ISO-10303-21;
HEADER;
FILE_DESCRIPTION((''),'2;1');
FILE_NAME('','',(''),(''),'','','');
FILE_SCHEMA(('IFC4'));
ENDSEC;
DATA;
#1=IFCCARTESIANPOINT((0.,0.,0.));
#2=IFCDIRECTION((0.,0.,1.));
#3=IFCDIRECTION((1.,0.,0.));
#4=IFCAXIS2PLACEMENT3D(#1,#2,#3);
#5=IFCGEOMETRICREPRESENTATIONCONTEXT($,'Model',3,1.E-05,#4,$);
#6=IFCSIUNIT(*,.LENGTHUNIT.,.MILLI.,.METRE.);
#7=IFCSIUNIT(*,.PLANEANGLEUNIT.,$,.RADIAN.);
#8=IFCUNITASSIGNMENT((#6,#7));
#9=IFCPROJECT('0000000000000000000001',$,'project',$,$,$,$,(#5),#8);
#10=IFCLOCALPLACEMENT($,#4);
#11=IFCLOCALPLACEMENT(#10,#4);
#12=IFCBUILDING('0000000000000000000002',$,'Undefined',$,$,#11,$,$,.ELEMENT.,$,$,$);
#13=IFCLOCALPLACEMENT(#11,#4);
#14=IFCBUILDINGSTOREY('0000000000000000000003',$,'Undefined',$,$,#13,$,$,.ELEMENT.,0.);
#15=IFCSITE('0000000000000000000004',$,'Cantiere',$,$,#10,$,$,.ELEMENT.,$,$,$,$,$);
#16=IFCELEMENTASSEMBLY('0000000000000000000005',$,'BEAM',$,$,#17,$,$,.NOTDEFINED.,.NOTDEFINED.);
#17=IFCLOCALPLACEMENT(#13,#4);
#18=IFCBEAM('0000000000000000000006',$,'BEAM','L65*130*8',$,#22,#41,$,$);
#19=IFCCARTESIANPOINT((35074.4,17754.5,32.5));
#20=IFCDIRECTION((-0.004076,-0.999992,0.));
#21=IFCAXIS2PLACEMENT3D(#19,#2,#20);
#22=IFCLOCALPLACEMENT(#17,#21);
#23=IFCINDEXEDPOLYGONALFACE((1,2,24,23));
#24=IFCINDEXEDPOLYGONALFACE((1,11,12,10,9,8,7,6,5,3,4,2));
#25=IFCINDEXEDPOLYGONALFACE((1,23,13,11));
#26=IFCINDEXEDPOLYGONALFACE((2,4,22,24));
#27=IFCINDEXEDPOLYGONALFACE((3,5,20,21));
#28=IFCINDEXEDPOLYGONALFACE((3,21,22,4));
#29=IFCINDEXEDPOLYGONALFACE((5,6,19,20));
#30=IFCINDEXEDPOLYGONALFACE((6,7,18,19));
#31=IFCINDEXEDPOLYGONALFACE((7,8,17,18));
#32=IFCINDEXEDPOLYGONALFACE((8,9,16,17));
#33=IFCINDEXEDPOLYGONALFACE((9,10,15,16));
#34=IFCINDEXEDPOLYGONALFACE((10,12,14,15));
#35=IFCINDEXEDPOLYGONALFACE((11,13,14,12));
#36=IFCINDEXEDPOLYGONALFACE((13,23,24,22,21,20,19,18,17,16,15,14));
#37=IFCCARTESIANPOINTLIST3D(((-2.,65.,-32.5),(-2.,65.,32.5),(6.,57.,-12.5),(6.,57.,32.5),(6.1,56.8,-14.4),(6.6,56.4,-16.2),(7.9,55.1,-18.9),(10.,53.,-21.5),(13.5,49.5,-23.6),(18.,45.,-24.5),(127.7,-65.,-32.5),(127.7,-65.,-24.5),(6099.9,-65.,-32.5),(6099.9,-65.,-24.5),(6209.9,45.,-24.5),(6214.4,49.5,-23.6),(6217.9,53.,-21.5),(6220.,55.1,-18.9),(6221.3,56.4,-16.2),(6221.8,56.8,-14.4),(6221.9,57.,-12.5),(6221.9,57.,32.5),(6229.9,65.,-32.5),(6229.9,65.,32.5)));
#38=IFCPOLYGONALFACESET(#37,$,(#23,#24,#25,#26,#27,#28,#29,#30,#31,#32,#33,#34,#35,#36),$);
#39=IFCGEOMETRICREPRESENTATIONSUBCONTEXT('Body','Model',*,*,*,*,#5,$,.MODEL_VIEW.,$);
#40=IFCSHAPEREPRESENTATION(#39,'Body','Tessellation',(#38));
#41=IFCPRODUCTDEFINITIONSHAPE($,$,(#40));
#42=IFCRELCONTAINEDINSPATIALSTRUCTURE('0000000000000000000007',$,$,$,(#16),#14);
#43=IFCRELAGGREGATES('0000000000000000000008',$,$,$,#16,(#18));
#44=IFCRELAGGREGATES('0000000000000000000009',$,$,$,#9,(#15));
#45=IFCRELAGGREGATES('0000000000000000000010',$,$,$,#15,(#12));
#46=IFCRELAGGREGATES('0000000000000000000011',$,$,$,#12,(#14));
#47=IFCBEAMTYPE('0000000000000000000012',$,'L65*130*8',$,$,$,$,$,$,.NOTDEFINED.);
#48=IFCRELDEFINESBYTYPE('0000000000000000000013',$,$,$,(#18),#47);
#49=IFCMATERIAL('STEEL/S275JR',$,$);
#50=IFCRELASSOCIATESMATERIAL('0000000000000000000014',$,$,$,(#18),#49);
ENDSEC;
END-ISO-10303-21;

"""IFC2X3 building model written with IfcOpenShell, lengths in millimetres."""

from ifc_helpers import new_model, si_unit, frame, origin_with_axes, origin_2d_with_axis, place, context, subcontext, project, spatial, l_section, extrude, clip, halfspace, material, type_object, element, aggregate, save


model = new_model("IFC2X3")

# Units and contexts
model_context = context("Model", 3, precision=1e-05, world=origin_with_axes())
body_context = subcontext(model_context, "Body", "Model", "MODEL_VIEW")
ifc_project = project(units=[si_unit("LENGTHUNIT", "METRE", prefix="MILLI"), si_unit("PLANEANGLEUNIT", "RADIAN")], contexts=[model_context])

# Site, building, storey
site_placement = place(None, origin_with_axes())
site = spatial("IfcSite", under=ifc_project, at=site_placement, Name="Cantiere", CompositionType="ELEMENT")
building_placement = place(site_placement, origin_with_axes())
building = spatial("IfcBuilding", under=site, at=building_placement, Name="Undefined", CompositionType="ELEMENT")
storey_placement = place(building_placement, origin_with_axes())
storey = spatial("IfcBuildingStorey", under=building, at=storey_placement, Name="Undefined", CompositionType="ELEMENT", Elevation=0.0)

# Element assembly, beam
assembly_1_placement = place(storey_placement, origin_with_axes())
assembly_1 = element("IfcElementAssembly", 1, at=assembly_1_placement, inside=storey, Name="BEAM", AssemblyPlace="NOTDEFINED", PredefinedType="NOTDEFINED")
ifc_material_1 = material(Name="STEEL/S275JR")
beam_type_1 = type_object("IfcBeamType", Name="L65*130*8", PredefinedType="NOTDEFINED")
beam_1_placement = place(assembly_1_placement, frame((35074.4, 17754.5, 32.5), z_axis=(0.0, 0.0, 1.0), x_axis=(-0.004076, -0.999992, 0.0)))
beam_1 = element("IfcBeam", 2, at=beam_1_placement, type_object=beam_type_1, material=ifc_material_1, Name="BEAM", Description="L65*130*8", context=body_context, shape_type="Clipping", body=[
    clip(clip(extrude(l_section(Depth=65.0, Width=130.0, Thickness=8.0, FilletRadius=12.0, at=origin_2d_with_axis()), frame((6296.6, 0.0, 0.0), z_axis=(-1.0, 0.0, 0.0), x_axis=(0.0, -1.0, 0.0)), (0.0, 0.0, 1.0), 6365.4), halfspace(frame((6099.9, -65.0, -32.5), z_axis=(0.707212, -0.707002, 0.0), x_axis=(0.0, 0.0, 1.0)), False)), halfspace(frame((127.7, -65.0, -32.5), z_axis=(0.707866, 0.706347, 0.0), x_axis=(0.0, 0.0, 1.0)), True)),
])
aggregate(assembly_1, [beam_1])

save(model, "model.ifc")
